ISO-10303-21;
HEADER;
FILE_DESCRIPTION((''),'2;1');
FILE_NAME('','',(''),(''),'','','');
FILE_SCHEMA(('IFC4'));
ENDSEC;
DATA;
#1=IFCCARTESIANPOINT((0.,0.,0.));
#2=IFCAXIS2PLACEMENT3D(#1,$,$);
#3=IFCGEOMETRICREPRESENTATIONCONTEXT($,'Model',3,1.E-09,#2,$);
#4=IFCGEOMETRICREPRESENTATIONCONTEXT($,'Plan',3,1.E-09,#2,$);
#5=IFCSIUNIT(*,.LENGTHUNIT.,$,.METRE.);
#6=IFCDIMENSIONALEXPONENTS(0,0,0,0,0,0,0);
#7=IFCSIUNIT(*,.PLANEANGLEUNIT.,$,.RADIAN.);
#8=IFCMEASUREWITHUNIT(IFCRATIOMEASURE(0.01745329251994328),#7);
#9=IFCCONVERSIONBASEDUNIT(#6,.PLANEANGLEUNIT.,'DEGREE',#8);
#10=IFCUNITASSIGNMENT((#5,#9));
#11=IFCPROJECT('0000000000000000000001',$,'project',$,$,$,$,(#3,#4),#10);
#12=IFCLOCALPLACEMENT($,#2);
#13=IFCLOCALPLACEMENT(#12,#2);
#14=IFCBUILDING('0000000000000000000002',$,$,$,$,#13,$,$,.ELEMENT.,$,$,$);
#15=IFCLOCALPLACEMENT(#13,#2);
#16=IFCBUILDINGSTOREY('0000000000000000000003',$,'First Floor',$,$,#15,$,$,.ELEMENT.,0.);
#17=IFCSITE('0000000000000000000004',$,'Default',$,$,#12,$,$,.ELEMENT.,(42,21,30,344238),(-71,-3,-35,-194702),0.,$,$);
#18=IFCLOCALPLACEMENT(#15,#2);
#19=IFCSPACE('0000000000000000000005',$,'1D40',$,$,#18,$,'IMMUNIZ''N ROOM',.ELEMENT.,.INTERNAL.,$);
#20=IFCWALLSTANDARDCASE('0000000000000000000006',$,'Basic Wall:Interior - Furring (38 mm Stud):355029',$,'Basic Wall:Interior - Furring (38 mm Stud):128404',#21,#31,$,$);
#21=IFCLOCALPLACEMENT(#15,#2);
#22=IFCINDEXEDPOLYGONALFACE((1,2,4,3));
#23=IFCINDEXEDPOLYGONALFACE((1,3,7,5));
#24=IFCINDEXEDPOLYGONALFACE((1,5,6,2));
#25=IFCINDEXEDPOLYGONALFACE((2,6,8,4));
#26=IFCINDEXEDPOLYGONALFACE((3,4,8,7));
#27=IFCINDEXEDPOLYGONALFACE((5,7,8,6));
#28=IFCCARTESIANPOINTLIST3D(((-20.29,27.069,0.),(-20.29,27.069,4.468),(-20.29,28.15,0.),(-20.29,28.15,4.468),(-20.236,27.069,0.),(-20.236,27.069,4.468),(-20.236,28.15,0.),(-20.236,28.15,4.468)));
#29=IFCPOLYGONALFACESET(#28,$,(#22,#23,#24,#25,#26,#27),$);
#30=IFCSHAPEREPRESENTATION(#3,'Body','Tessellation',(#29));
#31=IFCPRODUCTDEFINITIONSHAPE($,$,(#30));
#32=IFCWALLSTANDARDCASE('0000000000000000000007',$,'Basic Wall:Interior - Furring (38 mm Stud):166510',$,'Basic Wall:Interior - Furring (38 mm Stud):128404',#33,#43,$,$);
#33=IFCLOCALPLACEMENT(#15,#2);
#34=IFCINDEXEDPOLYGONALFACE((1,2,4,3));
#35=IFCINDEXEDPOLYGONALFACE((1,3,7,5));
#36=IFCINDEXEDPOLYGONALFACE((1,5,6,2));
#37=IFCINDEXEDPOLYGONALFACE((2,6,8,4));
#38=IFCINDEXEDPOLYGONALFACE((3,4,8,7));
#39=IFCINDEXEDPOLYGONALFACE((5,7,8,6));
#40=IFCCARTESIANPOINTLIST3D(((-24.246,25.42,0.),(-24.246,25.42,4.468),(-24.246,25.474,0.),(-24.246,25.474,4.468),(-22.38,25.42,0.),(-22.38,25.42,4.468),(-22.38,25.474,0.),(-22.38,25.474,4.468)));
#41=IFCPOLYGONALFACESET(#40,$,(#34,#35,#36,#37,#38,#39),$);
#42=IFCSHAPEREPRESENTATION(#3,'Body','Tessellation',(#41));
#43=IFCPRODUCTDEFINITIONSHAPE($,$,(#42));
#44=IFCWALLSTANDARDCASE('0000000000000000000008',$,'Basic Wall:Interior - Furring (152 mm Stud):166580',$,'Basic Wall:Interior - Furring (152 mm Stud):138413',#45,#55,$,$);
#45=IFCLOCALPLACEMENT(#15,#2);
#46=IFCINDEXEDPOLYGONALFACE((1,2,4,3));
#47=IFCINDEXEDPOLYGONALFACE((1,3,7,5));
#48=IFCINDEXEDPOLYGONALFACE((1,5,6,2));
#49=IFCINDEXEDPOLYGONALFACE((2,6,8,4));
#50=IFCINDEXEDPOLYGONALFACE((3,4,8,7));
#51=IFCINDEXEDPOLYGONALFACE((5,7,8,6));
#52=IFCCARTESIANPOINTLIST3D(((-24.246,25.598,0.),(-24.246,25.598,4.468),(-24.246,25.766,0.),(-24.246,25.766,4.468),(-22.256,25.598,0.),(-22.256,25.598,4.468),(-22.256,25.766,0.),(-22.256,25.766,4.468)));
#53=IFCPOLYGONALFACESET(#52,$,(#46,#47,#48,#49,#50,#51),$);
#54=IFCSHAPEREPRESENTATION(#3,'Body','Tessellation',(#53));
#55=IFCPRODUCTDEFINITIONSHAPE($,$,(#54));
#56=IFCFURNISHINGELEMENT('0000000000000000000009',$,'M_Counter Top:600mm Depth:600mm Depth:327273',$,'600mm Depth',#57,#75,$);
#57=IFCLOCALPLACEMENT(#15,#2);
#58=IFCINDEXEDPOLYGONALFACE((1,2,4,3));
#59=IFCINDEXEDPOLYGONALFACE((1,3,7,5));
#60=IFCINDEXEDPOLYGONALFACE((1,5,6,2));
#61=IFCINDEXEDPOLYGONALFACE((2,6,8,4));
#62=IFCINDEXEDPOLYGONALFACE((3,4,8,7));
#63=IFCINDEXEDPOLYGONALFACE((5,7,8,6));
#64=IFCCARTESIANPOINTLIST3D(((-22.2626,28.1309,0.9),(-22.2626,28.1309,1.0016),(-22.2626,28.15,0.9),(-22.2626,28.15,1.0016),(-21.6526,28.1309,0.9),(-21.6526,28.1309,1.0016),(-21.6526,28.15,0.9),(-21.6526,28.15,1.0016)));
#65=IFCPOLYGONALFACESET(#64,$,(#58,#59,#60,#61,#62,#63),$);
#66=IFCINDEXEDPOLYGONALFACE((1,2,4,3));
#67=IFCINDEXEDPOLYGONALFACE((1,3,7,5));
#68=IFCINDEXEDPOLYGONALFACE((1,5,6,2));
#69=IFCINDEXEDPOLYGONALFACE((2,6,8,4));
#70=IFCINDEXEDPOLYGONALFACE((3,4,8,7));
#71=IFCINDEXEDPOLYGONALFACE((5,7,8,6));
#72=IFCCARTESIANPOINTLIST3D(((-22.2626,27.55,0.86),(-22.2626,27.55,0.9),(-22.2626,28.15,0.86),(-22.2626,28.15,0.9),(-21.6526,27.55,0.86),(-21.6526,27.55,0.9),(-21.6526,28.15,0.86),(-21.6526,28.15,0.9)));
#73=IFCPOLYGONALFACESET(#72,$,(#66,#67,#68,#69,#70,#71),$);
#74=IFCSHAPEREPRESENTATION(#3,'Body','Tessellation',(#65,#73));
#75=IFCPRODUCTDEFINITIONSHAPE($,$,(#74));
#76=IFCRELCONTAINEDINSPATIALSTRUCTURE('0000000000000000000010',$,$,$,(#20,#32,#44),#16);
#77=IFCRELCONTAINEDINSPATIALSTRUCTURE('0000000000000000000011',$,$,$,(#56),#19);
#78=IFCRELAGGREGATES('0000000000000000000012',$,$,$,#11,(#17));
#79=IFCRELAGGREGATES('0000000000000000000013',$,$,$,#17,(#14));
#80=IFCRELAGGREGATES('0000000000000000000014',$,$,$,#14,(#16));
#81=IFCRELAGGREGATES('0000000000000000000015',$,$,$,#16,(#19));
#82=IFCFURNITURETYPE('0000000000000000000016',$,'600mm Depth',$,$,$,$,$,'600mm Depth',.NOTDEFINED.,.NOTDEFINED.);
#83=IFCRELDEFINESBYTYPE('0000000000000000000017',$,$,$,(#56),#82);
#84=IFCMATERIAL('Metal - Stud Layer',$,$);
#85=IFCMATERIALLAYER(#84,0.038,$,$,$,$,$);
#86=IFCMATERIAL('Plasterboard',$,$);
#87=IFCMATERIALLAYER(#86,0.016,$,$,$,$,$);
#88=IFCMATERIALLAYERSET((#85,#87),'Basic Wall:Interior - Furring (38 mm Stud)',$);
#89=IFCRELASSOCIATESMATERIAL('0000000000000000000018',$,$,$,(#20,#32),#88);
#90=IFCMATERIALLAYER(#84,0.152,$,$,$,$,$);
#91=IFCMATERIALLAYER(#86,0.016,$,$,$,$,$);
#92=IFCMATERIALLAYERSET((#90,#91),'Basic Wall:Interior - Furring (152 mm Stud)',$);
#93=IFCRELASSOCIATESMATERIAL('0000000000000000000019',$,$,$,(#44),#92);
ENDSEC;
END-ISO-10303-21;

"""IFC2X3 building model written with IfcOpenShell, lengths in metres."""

from ifc_helpers import new_model, entity, si_unit, converted_unit, frame, frame_2d, origin, origin_2d_with_axis, place, context, project, spatial, rectangle, extrude, source, transform, mapped, material, layer, layer_set, layer_usage, type_object, type_shapes, element, save


model = new_model("IFC2X3")

# Units and contexts
model_context = context("Model", 3, precision=1e-09, world=origin())
plan_context = context("Plan", 3, precision=1e-09, world=origin())
ifc_project = project(units=[si_unit("LENGTHUNIT", "METRE"), converted_unit("PLANEANGLEUNIT", "DEGREE", entity("IfcRatioMeasure", 0.01745329251994328), si_unit("PLANEANGLEUNIT", "RADIAN"), dimensions=[0, 0, 0, 0, 0, 0, 0])], contexts=[model_context, plan_context])

# Site, building, storey
site_placement = place(None, origin())
site = spatial("IfcSite", under=ifc_project, at=site_placement, Name="Default", CompositionType="ELEMENT", RefLatitude=(42, 21, 30, 344238), RefLongitude=(-71, -3, -35, -194702), RefElevation=0.0)
building_placement = place(site_placement, origin())
building = spatial("IfcBuilding", under=site, at=building_placement, CompositionType="ELEMENT")
storey_placement = place(building_placement, origin())
storey = spatial("IfcBuildingStorey", under=building, at=storey_placement, Name="First Floor", CompositionType="ELEMENT", Elevation=0.0)

# Shared definitions
ifc_material_1 = material(Name="Metal - Stud Layer")
ifc_layer_1 = layer(ifc_material_1, 0.152)
ifc_material_2 = material(Name="Plasterboard")
ifc_layer_2 = layer(ifc_material_2, 0.016)
ifc_layer_set_1 = layer_set([ifc_layer_1, ifc_layer_2], Name="Basic Wall:Interior - Furring (152 mm Stud)")
ifc_layer_usage_1 = layer_usage(ifc_layer_set_1, "AXIS2", "POSITIVE", -0.084)

# Shared definitions
ifc_layer_3 = layer(ifc_material_1, 0.038)
ifc_layer_4 = layer(ifc_material_2, 0.016)
ifc_layer_set_2 = layer_set([ifc_layer_3, ifc_layer_4], Name="Basic Wall:Interior - Furring (38 mm Stud)")
ifc_layer_usage_2 = layer_usage(ifc_layer_set_2, "AXIS2", "NEGATIVE", 0.027)

# Walls
wall_1_placement = place(storey_placement, frame((-20.263, 28.15, 0.0), z_axis=(0.0, 0.0, 1.0), x_axis=(0.0, -1.0, 0.0)))
element("IfcWallStandardCase", 1, at=wall_1_placement, inside=storey, material=ifc_layer_usage_2, Name="Basic Wall:Interior - Furring (38 mm Stud):355029", ObjectType="Basic Wall:Interior - Furring (38 mm Stud):128404", context=model_context, shape_type="SweptSolid", body=[
    extrude(rectangle(XDim=1.081, YDim=0.054, at=frame_2d((0.5405, 0.0), x_axis=(-1.0, 0.0))), origin(), (0.0, 0.0, 1.0), 4.468),
])
ifc_layer_usage_3 = layer_usage(ifc_layer_set_2, "AXIS2", "POSITIVE", -0.027)
wall_2_placement = place(storey_placement, frame((-22.38, 25.447, 0.0), z_axis=(0.0, 0.0, 1.0), x_axis=(-1.0, 0.0, 0.0)))
element("IfcWallStandardCase", 2, at=wall_2_placement, inside=storey, material=ifc_layer_usage_3, Name="Basic Wall:Interior - Furring (38 mm Stud):166510", ObjectType="Basic Wall:Interior - Furring (38 mm Stud):128404", context=model_context, shape_type="SweptSolid", body=[
    extrude(rectangle(XDim=1.866, YDim=0.054, at=frame_2d((0.933, 0.0), x_axis=(-1.0, 0.0))), origin(), (0.0, 0.0, 1.0), 4.468),
])
wall_3_placement = place(storey_placement, frame((-24.246, 25.682, 0.0)))
element("IfcWallStandardCase", 3, at=wall_3_placement, inside=storey, material=ifc_layer_usage_1, Name="Basic Wall:Interior - Furring (152 mm Stud):166580", ObjectType="Basic Wall:Interior - Furring (152 mm Stud):138413", context=model_context, shape_type="SweptSolid", body=[
    extrude(rectangle(XDim=1.99, YDim=0.168, at=frame_2d((0.995, 0.0), x_axis=(-1.0, 0.0))), origin(), (0.0, 0.0, 1.0), 4.468),
])

# Shared definitions
space_placement = place(storey_placement, origin())
space = spatial("IfcSpace", under=storey, at=space_placement, Name="1D40", LongName="IMMUNIZ'N ROOM", CompositionType="ELEMENT", InteriorOrExteriorSpace="INTERNAL")

# Furnishing element
furniture_type = type_object("IfcFurnitureType", Name="600mm Depth", ElementType="600mm Depth", AssemblyPlace="NOTDEFINED")
shared_shape_1 = source(origin(), model_context, "Body", "SweptSolid", [
    extrude(rectangle(XDim=0.0191, YDim=0.61, at=origin_2d_with_axis()), frame((-0.8955, -0.0095, 0.9), z_axis=(0.0, 0.0, 1.0), x_axis=(0.0, -1.0, 0.0)), (0.0, 0.0, 1.0), 0.1016),
    extrude(rectangle(XDim=0.61, YDim=0.6, at=origin_2d_with_axis()), frame((-0.8955, -0.3, 0.86), z_axis=(0.0, 0.0, 1.0), x_axis=(-1.0, 0.0, 0.0)), (0.0, 0.0, 1.0), 0.04),
])
type_shapes(furniture_type, [shared_shape_1])
furnishing_placement = place(space_placement, frame((-21.0621, 28.15, 0.0)))
element("IfcFurnishingElement", 4, at=furnishing_placement, inside=space, type_object=furniture_type, Name="M_Counter Top:600mm Depth:600mm Depth:327273", ObjectType="600mm Depth", context=model_context, shape_type="MappedRepresentation", body=[
    mapped(shared_shape_1, transform((0.0, 0.0, 0.0), scale=1.0)),
])

save(model, "model.ifc")
